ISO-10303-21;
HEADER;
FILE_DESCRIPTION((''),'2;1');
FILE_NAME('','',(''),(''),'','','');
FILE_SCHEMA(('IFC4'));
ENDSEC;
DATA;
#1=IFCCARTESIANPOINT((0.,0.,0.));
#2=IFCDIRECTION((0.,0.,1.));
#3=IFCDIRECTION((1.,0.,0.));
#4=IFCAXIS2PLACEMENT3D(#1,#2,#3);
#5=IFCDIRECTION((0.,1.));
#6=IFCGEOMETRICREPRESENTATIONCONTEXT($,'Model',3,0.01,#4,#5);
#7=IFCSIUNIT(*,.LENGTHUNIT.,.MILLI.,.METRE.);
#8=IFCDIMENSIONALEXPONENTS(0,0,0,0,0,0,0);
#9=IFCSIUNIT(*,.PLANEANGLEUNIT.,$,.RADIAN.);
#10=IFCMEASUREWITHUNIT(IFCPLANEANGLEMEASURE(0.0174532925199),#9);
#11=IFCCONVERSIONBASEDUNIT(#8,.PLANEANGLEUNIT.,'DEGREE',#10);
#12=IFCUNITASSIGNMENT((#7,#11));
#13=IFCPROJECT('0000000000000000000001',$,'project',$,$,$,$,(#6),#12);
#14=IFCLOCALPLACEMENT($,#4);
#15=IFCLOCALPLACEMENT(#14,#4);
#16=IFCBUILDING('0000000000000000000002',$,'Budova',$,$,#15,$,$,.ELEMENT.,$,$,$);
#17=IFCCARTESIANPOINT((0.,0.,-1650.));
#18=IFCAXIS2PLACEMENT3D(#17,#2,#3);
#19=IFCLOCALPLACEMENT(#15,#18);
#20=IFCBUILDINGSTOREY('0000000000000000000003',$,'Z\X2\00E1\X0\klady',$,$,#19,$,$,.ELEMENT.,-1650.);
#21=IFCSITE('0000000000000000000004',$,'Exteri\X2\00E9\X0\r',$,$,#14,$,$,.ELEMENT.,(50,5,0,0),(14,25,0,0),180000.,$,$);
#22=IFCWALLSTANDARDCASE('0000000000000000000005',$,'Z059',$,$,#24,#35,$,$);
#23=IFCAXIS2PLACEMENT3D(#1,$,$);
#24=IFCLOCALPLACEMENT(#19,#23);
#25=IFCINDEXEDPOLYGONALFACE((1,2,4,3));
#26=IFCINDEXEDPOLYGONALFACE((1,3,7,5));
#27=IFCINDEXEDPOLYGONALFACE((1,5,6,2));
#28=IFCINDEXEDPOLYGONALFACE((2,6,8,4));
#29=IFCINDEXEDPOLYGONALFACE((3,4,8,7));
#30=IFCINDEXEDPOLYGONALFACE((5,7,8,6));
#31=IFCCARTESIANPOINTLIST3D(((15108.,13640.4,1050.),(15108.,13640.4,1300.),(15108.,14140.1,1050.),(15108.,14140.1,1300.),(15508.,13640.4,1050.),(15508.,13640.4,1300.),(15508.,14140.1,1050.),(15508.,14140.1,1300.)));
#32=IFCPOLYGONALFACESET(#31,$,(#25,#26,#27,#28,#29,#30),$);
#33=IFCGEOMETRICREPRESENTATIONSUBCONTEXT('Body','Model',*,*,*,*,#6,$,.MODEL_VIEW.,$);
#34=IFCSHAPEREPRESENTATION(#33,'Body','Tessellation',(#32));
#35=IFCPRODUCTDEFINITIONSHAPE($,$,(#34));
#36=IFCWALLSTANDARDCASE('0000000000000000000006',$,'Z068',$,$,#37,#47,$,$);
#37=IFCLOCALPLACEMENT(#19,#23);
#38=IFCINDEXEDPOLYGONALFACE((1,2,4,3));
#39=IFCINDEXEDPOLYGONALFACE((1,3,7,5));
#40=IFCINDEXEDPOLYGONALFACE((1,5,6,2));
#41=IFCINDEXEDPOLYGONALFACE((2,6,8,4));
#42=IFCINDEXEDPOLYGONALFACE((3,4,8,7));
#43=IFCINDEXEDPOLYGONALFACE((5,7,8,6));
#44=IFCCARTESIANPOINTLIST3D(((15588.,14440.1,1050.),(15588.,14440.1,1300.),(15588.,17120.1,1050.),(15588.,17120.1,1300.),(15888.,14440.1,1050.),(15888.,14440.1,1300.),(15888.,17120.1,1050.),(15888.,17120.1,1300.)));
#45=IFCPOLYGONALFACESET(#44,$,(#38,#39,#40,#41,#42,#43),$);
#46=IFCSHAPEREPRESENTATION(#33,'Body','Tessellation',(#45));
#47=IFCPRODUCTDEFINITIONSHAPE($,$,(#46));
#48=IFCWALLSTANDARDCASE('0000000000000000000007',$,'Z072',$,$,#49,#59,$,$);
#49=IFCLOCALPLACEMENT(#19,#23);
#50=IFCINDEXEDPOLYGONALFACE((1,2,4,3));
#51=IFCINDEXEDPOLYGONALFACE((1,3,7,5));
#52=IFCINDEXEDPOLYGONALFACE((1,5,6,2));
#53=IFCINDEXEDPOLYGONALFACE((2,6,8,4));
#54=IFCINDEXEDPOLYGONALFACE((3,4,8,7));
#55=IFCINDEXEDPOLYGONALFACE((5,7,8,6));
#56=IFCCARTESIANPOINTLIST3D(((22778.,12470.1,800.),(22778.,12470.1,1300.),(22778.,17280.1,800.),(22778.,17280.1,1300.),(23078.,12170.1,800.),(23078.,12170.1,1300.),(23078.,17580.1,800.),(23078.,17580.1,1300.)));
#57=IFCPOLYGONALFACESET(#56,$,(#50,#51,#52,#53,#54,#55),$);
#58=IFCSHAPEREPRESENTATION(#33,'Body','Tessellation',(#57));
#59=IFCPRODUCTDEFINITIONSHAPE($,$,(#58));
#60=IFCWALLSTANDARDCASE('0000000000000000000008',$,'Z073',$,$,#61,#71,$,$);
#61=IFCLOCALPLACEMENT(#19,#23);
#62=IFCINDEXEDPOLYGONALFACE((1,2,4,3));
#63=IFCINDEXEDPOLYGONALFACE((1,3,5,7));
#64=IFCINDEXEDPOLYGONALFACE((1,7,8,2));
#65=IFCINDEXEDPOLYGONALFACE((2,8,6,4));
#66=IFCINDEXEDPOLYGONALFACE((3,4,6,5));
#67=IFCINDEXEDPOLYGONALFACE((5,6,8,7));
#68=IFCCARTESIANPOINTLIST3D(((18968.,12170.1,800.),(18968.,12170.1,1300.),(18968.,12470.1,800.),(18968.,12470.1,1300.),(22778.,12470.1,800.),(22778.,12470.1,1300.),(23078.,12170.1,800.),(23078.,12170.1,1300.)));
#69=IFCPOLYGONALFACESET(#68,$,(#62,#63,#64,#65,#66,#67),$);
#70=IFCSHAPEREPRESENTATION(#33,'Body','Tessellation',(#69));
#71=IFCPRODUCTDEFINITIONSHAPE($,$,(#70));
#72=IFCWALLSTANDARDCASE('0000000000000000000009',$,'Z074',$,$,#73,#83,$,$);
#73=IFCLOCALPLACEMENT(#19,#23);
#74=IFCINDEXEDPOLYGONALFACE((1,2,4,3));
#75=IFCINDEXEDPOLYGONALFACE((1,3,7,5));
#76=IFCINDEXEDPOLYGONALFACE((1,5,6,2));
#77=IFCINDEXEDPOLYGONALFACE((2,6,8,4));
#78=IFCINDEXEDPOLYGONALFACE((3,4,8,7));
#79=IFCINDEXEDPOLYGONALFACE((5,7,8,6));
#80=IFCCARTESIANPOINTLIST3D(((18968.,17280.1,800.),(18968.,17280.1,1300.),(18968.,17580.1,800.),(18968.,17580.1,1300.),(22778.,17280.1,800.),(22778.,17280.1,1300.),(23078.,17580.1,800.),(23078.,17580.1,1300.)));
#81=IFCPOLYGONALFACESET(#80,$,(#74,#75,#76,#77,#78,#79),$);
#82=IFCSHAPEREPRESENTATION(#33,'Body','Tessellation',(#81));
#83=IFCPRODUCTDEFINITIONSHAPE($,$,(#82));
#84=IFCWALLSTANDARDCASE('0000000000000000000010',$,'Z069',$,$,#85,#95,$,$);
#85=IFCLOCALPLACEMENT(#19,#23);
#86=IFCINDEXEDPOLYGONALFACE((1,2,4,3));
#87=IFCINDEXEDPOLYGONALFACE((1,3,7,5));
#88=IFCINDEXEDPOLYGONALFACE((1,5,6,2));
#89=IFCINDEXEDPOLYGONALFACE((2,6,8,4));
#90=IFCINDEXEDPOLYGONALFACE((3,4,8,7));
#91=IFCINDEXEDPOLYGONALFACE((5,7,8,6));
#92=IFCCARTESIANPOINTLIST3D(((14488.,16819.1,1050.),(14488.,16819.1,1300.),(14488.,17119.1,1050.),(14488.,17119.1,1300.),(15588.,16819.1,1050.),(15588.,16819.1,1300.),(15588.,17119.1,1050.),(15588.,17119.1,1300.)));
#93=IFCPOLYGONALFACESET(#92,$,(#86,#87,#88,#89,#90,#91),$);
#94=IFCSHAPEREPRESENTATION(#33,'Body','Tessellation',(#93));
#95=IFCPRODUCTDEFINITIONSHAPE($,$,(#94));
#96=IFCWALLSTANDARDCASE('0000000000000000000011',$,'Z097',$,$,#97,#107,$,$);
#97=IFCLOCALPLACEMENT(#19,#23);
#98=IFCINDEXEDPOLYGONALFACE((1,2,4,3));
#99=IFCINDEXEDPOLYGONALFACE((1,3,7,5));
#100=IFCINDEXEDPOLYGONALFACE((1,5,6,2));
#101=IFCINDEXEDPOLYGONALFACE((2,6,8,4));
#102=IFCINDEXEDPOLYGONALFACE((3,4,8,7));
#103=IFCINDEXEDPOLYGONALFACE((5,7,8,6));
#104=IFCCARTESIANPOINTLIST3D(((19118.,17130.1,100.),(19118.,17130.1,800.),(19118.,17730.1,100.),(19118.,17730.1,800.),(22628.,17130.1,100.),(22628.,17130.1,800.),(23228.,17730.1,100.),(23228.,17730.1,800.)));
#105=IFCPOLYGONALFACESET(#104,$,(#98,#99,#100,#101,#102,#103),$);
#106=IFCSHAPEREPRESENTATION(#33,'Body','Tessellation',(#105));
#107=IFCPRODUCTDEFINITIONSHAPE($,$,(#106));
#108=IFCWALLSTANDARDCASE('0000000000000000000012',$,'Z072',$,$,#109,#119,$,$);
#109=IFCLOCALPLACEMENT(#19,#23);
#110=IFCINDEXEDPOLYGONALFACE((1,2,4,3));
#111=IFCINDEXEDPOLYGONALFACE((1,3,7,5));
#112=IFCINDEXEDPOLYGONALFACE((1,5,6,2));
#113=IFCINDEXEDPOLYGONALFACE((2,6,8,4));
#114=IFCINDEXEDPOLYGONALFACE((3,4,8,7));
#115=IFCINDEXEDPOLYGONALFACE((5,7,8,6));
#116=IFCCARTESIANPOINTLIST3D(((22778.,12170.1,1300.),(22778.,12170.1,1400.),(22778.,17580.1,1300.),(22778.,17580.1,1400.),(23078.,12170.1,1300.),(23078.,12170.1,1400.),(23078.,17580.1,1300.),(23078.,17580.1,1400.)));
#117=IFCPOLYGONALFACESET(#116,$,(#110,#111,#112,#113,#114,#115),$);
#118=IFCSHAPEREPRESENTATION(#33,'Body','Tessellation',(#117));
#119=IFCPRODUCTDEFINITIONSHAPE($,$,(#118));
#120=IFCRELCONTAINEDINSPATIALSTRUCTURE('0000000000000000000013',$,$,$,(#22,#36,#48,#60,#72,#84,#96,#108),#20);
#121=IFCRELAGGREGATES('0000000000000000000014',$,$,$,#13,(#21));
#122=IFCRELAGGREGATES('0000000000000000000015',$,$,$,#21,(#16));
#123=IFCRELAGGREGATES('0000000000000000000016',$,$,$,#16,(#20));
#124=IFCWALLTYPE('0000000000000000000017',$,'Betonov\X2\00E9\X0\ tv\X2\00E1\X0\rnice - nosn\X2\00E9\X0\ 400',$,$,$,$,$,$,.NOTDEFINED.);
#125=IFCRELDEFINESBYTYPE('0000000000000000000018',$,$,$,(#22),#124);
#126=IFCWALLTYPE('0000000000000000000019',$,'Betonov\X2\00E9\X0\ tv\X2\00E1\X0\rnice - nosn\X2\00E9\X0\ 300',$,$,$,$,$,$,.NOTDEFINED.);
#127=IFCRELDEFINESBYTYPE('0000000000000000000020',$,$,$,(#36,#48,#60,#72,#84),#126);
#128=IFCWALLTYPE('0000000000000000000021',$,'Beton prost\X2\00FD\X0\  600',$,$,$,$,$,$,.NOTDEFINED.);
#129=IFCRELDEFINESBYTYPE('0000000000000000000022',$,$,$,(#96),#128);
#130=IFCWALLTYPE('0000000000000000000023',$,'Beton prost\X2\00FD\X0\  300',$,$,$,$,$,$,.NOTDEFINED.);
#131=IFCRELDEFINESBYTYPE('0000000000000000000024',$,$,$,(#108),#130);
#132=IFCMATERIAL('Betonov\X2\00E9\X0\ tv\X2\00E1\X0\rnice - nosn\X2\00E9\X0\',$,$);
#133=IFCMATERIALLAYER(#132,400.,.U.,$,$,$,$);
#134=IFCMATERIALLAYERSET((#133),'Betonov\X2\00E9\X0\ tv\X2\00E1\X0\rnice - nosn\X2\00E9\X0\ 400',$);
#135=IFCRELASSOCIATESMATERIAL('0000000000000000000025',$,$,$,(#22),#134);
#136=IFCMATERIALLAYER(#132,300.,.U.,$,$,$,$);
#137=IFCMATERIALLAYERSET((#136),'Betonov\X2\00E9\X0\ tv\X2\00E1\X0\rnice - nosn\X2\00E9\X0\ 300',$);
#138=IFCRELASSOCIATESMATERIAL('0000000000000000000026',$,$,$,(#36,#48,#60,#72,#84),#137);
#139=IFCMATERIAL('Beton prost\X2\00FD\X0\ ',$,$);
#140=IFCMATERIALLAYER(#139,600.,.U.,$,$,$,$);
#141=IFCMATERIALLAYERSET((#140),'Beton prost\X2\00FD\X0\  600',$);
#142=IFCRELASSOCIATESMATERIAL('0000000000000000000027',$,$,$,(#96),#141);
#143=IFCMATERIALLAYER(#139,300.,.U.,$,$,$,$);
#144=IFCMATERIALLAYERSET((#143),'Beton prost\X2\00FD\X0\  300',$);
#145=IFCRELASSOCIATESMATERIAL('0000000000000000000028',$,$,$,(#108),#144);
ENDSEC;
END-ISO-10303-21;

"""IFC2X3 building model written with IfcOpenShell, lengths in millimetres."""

from ifc_helpers import new_model, entity, si_unit, converted_unit, direction, frame, origin_with_axes, place, context, subcontext, project, spatial, polyline, outline, extrude, material, layer, layer_set, layer_usage, type_object, element, save


model = new_model("IFC2X3")

# Units and contexts
model_context = context("Model", 3, precision=0.01, world=origin_with_axes(), true_north=direction((0.0, 1.0)))
body_context = subcontext(model_context, "Body", "Model", "MODEL_VIEW")
ifc_project = project(units=[si_unit("LENGTHUNIT", "METRE", prefix="MILLI"), converted_unit("PLANEANGLEUNIT", "DEGREE", entity("IfcPlaneAngleMeasure", 0.0174532925199), si_unit("PLANEANGLEUNIT", "RADIAN"), dimensions=[0, 0, 0, 0, 0, 0, 0])], contexts=[model_context])

# Site, building, storey
site_placement = place(None, origin_with_axes())
site = spatial("IfcSite", under=ifc_project, at=site_placement, Name="Exteriér", CompositionType="ELEMENT", RefLatitude=(50, 5, 0, 0), RefLongitude=(14, 25, 0, 0), RefElevation=180000.0)
building_placement = place(site_placement, origin_with_axes())
building = spatial("IfcBuilding", under=site, at=building_placement, Name="Budova", CompositionType="ELEMENT")
storey_placement = place(building_placement, frame((0.0, 0.0, -1650.0), z_axis=(0.0, 0.0, 1.0), x_axis=(1.0, 0.0, 0.0)))
storey = spatial("IfcBuildingStorey", under=building, at=storey_placement, Name="Základy", CompositionType="ELEMENT", Elevation=-1650.0)

# Walls
ifc_material_1 = material(Name="Betonové tvárnice - nosné")
ifc_layer_1 = layer(ifc_material_1, 400.0, ventilated="UNKNOWN")
ifc_layer_set_1 = layer_set([ifc_layer_1], Name="Betonové tvárnice - nosné 400")
wall_type_1 = type_object("IfcWallType", Name="Betonové tvárnice - nosné 400", PredefinedType="NOTDEFINED")
ifc_layer_usage_1 = layer_usage(ifc_layer_set_1, "AXIS2", "POSITIVE", 0.0)
wall_1_placement = place(storey_placement, frame((15108.0, 14140.1, 1050.0), z_axis=(0.0, 0.0, 1.0), x_axis=(0.0, -1.0, 0.0)))
element("IfcWallStandardCase", 1, at=wall_1_placement, inside=storey, type_object=wall_type_1, material=ifc_layer_usage_1, Name="Z059", context=body_context, shape_type="SweptSolid", body=[
    extrude(outline(polyline([(0.0, 0.0), (499.7, 0.0), (499.7, 400.0), (0.0, 400.0), (0.0, 0.0)])), origin_with_axes(), (0.0, 0.0, 1.0), 250.0),
])
ifc_layer_2 = layer(ifc_material_1, 300.0, ventilated="UNKNOWN")
ifc_layer_set_2 = layer_set([ifc_layer_2], Name="Betonové tvárnice - nosné 300")
wall_type_2 = type_object("IfcWallType", Name="Betonové tvárnice - nosné 300", PredefinedType="NOTDEFINED")
ifc_layer_usage_2 = layer_usage(ifc_layer_set_2, "AXIS2", "POSITIVE", 0.0)
wall_2_placement = place(storey_placement, frame((15588.0, 17120.1, 1050.0), z_axis=(0.0, 0.0, 1.0), x_axis=(0.0, -1.0, 0.0)))
element("IfcWallStandardCase", 2, at=wall_2_placement, inside=storey, type_object=wall_type_2, material=ifc_layer_usage_2, Name="Z068", context=body_context, shape_type="SweptSolid", body=[
    extrude(outline(polyline([(0.0, 0.0), (2680.0, 0.0), (2680.0, 300.0), (0.0, 300.0), (0.0, 0.0)])), origin_with_axes(), (0.0, 0.0, 1.0), 250.0),
])
ifc_layer_usage_3 = layer_usage(ifc_layer_set_2, "AXIS2", "POSITIVE", -300.0)
wall_3_placement = place(storey_placement, frame((23078.0, 17580.1, 800.0), z_axis=(0.0, 0.0, 1.0), x_axis=(0.0, -1.0, 0.0)))
element("IfcWallStandardCase", 3, at=wall_3_placement, inside=storey, type_object=wall_type_2, material=ifc_layer_usage_3, Name="Z072", context=body_context, shape_type="SweptSolid", body=[
    extrude(outline(polyline([(300.0, -300.0), (5110.0, -300.0), (5410.0, 0.0), (0.0, 0.0), (300.0, -300.0)])), origin_with_axes(), (0.0, 0.0, 1.0), 500.0),
])
ifc_layer_usage_4 = layer_usage(ifc_layer_set_2, "AXIS2", "POSITIVE", -300.0)
wall_4_placement = place(storey_placement, frame((23078.0, 12170.1, 800.0), z_axis=(0.0, 0.0, 1.0), x_axis=(-1.0, 0.0, 0.0)))
element("IfcWallStandardCase", 4, at=wall_4_placement, inside=storey, type_object=wall_type_2, material=ifc_layer_usage_4, Name="Z073", context=body_context, shape_type="SweptSolid", body=[
    extrude(outline(polyline([(300.0, -300.0), (4110.0, -300.0), (4110.0, 0.0), (0.0, 0.0), (300.0, -300.0)])), origin_with_axes(), (0.0, 0.0, 1.0), 500.0),
])
ifc_layer_usage_5 = layer_usage(ifc_layer_set_2, "AXIS2", "POSITIVE", 0.0)
wall_5_placement = place(storey_placement, frame((23078.0, 17580.1, 800.0), z_axis=(0.0, 0.0, 1.0), x_axis=(-1.0, 0.0, 0.0)))
element("IfcWallStandardCase", 5, at=wall_5_placement, inside=storey, type_object=wall_type_2, material=ifc_layer_usage_5, Name="Z074", context=body_context, shape_type="SweptSolid", body=[
    extrude(outline(polyline([(0.0, 0.0), (4110.0, 0.0), (4110.0, 300.0), (300.0, 300.0), (0.0, 0.0)])), origin_with_axes(), (0.0, 0.0, 1.0), 500.0),
])
ifc_layer_usage_6 = layer_usage(ifc_layer_set_2, "AXIS2", "POSITIVE", -300.0)
wall_6_placement = place(storey_placement, frame((14488.0, 17119.1, 1050.0), z_axis=(0.0, 0.0, 1.0), x_axis=(1.0, 0.0, 0.0)))
element("IfcWallStandardCase", 6, at=wall_6_placement, inside=storey, type_object=wall_type_2, material=ifc_layer_usage_6, Name="Z069", context=body_context, shape_type="SweptSolid", body=[
    extrude(outline(polyline([(0.0, -300.0), (1100.0, -300.0), (1100.0, 0.0), (0.0, 0.0), (0.0, -300.0)])), origin_with_axes(), (0.0, 0.0, 1.0), 250.0),
])
ifc_material_2 = material(Name="Beton prostý ")
ifc_layer_3 = layer(ifc_material_2, 600.0, ventilated="UNKNOWN")
ifc_layer_set_3 = layer_set([ifc_layer_3], Name="Beton prostý  600")
wall_type_3 = type_object("IfcWallType", Name="Beton prostý  600", PredefinedType="NOTDEFINED")
ifc_layer_usage_7 = layer_usage(ifc_layer_set_3, "AXIS2", "POSITIVE", -450.0)
wall_7_placement = place(storey_placement, frame((19118.0, 17580.1, 100.0), z_axis=(0.0, 0.0, 1.0), x_axis=(1.0, 0.0, 0.0)))
element("IfcWallStandardCase", 7, at=wall_7_placement, inside=storey, type_object=wall_type_3, material=ifc_layer_usage_7, Name="Z097", context=body_context, shape_type="SweptSolid", body=[
    extrude(outline(polyline([(0.0, -450.0), (3510.0, -450.0), (4110.0, 150.0), (0.0, 150.0), (0.0, -450.0)])), origin_with_axes(), (0.0, 0.0, 1.0), 700.0),
])
ifc_layer_4 = layer(ifc_material_2, 300.0, ventilated="UNKNOWN")
ifc_layer_set_4 = layer_set([ifc_layer_4], Name="Beton prostý  300")
ifc_layer_usage_8 = layer_usage(ifc_layer_set_4, "AXIS2", "POSITIVE", -300.0)
wall_type_4 = type_object("IfcWallType", Name="Beton prostý  300", PredefinedType="NOTDEFINED")
wall_8_placement = place(storey_placement, frame((23078.0, 17580.1, 1300.0), z_axis=(0.0, 0.0, 1.0), x_axis=(0.0, -1.0, 0.0)))
element("IfcWallStandardCase", 8, at=wall_8_placement, inside=storey, type_object=wall_type_4, material=ifc_layer_usage_8, Name="Z072", context=body_context, shape_type="SweptSolid", body=[
    extrude(outline(polyline([(0.0, -300.0), (5410.0, -300.0), (5410.0, 0.0), (0.0, 0.0), (0.0, -300.0)])), origin_with_axes(), (0.0, 0.0, 1.0), 100.0),
])

save(model, "model.ifc")
